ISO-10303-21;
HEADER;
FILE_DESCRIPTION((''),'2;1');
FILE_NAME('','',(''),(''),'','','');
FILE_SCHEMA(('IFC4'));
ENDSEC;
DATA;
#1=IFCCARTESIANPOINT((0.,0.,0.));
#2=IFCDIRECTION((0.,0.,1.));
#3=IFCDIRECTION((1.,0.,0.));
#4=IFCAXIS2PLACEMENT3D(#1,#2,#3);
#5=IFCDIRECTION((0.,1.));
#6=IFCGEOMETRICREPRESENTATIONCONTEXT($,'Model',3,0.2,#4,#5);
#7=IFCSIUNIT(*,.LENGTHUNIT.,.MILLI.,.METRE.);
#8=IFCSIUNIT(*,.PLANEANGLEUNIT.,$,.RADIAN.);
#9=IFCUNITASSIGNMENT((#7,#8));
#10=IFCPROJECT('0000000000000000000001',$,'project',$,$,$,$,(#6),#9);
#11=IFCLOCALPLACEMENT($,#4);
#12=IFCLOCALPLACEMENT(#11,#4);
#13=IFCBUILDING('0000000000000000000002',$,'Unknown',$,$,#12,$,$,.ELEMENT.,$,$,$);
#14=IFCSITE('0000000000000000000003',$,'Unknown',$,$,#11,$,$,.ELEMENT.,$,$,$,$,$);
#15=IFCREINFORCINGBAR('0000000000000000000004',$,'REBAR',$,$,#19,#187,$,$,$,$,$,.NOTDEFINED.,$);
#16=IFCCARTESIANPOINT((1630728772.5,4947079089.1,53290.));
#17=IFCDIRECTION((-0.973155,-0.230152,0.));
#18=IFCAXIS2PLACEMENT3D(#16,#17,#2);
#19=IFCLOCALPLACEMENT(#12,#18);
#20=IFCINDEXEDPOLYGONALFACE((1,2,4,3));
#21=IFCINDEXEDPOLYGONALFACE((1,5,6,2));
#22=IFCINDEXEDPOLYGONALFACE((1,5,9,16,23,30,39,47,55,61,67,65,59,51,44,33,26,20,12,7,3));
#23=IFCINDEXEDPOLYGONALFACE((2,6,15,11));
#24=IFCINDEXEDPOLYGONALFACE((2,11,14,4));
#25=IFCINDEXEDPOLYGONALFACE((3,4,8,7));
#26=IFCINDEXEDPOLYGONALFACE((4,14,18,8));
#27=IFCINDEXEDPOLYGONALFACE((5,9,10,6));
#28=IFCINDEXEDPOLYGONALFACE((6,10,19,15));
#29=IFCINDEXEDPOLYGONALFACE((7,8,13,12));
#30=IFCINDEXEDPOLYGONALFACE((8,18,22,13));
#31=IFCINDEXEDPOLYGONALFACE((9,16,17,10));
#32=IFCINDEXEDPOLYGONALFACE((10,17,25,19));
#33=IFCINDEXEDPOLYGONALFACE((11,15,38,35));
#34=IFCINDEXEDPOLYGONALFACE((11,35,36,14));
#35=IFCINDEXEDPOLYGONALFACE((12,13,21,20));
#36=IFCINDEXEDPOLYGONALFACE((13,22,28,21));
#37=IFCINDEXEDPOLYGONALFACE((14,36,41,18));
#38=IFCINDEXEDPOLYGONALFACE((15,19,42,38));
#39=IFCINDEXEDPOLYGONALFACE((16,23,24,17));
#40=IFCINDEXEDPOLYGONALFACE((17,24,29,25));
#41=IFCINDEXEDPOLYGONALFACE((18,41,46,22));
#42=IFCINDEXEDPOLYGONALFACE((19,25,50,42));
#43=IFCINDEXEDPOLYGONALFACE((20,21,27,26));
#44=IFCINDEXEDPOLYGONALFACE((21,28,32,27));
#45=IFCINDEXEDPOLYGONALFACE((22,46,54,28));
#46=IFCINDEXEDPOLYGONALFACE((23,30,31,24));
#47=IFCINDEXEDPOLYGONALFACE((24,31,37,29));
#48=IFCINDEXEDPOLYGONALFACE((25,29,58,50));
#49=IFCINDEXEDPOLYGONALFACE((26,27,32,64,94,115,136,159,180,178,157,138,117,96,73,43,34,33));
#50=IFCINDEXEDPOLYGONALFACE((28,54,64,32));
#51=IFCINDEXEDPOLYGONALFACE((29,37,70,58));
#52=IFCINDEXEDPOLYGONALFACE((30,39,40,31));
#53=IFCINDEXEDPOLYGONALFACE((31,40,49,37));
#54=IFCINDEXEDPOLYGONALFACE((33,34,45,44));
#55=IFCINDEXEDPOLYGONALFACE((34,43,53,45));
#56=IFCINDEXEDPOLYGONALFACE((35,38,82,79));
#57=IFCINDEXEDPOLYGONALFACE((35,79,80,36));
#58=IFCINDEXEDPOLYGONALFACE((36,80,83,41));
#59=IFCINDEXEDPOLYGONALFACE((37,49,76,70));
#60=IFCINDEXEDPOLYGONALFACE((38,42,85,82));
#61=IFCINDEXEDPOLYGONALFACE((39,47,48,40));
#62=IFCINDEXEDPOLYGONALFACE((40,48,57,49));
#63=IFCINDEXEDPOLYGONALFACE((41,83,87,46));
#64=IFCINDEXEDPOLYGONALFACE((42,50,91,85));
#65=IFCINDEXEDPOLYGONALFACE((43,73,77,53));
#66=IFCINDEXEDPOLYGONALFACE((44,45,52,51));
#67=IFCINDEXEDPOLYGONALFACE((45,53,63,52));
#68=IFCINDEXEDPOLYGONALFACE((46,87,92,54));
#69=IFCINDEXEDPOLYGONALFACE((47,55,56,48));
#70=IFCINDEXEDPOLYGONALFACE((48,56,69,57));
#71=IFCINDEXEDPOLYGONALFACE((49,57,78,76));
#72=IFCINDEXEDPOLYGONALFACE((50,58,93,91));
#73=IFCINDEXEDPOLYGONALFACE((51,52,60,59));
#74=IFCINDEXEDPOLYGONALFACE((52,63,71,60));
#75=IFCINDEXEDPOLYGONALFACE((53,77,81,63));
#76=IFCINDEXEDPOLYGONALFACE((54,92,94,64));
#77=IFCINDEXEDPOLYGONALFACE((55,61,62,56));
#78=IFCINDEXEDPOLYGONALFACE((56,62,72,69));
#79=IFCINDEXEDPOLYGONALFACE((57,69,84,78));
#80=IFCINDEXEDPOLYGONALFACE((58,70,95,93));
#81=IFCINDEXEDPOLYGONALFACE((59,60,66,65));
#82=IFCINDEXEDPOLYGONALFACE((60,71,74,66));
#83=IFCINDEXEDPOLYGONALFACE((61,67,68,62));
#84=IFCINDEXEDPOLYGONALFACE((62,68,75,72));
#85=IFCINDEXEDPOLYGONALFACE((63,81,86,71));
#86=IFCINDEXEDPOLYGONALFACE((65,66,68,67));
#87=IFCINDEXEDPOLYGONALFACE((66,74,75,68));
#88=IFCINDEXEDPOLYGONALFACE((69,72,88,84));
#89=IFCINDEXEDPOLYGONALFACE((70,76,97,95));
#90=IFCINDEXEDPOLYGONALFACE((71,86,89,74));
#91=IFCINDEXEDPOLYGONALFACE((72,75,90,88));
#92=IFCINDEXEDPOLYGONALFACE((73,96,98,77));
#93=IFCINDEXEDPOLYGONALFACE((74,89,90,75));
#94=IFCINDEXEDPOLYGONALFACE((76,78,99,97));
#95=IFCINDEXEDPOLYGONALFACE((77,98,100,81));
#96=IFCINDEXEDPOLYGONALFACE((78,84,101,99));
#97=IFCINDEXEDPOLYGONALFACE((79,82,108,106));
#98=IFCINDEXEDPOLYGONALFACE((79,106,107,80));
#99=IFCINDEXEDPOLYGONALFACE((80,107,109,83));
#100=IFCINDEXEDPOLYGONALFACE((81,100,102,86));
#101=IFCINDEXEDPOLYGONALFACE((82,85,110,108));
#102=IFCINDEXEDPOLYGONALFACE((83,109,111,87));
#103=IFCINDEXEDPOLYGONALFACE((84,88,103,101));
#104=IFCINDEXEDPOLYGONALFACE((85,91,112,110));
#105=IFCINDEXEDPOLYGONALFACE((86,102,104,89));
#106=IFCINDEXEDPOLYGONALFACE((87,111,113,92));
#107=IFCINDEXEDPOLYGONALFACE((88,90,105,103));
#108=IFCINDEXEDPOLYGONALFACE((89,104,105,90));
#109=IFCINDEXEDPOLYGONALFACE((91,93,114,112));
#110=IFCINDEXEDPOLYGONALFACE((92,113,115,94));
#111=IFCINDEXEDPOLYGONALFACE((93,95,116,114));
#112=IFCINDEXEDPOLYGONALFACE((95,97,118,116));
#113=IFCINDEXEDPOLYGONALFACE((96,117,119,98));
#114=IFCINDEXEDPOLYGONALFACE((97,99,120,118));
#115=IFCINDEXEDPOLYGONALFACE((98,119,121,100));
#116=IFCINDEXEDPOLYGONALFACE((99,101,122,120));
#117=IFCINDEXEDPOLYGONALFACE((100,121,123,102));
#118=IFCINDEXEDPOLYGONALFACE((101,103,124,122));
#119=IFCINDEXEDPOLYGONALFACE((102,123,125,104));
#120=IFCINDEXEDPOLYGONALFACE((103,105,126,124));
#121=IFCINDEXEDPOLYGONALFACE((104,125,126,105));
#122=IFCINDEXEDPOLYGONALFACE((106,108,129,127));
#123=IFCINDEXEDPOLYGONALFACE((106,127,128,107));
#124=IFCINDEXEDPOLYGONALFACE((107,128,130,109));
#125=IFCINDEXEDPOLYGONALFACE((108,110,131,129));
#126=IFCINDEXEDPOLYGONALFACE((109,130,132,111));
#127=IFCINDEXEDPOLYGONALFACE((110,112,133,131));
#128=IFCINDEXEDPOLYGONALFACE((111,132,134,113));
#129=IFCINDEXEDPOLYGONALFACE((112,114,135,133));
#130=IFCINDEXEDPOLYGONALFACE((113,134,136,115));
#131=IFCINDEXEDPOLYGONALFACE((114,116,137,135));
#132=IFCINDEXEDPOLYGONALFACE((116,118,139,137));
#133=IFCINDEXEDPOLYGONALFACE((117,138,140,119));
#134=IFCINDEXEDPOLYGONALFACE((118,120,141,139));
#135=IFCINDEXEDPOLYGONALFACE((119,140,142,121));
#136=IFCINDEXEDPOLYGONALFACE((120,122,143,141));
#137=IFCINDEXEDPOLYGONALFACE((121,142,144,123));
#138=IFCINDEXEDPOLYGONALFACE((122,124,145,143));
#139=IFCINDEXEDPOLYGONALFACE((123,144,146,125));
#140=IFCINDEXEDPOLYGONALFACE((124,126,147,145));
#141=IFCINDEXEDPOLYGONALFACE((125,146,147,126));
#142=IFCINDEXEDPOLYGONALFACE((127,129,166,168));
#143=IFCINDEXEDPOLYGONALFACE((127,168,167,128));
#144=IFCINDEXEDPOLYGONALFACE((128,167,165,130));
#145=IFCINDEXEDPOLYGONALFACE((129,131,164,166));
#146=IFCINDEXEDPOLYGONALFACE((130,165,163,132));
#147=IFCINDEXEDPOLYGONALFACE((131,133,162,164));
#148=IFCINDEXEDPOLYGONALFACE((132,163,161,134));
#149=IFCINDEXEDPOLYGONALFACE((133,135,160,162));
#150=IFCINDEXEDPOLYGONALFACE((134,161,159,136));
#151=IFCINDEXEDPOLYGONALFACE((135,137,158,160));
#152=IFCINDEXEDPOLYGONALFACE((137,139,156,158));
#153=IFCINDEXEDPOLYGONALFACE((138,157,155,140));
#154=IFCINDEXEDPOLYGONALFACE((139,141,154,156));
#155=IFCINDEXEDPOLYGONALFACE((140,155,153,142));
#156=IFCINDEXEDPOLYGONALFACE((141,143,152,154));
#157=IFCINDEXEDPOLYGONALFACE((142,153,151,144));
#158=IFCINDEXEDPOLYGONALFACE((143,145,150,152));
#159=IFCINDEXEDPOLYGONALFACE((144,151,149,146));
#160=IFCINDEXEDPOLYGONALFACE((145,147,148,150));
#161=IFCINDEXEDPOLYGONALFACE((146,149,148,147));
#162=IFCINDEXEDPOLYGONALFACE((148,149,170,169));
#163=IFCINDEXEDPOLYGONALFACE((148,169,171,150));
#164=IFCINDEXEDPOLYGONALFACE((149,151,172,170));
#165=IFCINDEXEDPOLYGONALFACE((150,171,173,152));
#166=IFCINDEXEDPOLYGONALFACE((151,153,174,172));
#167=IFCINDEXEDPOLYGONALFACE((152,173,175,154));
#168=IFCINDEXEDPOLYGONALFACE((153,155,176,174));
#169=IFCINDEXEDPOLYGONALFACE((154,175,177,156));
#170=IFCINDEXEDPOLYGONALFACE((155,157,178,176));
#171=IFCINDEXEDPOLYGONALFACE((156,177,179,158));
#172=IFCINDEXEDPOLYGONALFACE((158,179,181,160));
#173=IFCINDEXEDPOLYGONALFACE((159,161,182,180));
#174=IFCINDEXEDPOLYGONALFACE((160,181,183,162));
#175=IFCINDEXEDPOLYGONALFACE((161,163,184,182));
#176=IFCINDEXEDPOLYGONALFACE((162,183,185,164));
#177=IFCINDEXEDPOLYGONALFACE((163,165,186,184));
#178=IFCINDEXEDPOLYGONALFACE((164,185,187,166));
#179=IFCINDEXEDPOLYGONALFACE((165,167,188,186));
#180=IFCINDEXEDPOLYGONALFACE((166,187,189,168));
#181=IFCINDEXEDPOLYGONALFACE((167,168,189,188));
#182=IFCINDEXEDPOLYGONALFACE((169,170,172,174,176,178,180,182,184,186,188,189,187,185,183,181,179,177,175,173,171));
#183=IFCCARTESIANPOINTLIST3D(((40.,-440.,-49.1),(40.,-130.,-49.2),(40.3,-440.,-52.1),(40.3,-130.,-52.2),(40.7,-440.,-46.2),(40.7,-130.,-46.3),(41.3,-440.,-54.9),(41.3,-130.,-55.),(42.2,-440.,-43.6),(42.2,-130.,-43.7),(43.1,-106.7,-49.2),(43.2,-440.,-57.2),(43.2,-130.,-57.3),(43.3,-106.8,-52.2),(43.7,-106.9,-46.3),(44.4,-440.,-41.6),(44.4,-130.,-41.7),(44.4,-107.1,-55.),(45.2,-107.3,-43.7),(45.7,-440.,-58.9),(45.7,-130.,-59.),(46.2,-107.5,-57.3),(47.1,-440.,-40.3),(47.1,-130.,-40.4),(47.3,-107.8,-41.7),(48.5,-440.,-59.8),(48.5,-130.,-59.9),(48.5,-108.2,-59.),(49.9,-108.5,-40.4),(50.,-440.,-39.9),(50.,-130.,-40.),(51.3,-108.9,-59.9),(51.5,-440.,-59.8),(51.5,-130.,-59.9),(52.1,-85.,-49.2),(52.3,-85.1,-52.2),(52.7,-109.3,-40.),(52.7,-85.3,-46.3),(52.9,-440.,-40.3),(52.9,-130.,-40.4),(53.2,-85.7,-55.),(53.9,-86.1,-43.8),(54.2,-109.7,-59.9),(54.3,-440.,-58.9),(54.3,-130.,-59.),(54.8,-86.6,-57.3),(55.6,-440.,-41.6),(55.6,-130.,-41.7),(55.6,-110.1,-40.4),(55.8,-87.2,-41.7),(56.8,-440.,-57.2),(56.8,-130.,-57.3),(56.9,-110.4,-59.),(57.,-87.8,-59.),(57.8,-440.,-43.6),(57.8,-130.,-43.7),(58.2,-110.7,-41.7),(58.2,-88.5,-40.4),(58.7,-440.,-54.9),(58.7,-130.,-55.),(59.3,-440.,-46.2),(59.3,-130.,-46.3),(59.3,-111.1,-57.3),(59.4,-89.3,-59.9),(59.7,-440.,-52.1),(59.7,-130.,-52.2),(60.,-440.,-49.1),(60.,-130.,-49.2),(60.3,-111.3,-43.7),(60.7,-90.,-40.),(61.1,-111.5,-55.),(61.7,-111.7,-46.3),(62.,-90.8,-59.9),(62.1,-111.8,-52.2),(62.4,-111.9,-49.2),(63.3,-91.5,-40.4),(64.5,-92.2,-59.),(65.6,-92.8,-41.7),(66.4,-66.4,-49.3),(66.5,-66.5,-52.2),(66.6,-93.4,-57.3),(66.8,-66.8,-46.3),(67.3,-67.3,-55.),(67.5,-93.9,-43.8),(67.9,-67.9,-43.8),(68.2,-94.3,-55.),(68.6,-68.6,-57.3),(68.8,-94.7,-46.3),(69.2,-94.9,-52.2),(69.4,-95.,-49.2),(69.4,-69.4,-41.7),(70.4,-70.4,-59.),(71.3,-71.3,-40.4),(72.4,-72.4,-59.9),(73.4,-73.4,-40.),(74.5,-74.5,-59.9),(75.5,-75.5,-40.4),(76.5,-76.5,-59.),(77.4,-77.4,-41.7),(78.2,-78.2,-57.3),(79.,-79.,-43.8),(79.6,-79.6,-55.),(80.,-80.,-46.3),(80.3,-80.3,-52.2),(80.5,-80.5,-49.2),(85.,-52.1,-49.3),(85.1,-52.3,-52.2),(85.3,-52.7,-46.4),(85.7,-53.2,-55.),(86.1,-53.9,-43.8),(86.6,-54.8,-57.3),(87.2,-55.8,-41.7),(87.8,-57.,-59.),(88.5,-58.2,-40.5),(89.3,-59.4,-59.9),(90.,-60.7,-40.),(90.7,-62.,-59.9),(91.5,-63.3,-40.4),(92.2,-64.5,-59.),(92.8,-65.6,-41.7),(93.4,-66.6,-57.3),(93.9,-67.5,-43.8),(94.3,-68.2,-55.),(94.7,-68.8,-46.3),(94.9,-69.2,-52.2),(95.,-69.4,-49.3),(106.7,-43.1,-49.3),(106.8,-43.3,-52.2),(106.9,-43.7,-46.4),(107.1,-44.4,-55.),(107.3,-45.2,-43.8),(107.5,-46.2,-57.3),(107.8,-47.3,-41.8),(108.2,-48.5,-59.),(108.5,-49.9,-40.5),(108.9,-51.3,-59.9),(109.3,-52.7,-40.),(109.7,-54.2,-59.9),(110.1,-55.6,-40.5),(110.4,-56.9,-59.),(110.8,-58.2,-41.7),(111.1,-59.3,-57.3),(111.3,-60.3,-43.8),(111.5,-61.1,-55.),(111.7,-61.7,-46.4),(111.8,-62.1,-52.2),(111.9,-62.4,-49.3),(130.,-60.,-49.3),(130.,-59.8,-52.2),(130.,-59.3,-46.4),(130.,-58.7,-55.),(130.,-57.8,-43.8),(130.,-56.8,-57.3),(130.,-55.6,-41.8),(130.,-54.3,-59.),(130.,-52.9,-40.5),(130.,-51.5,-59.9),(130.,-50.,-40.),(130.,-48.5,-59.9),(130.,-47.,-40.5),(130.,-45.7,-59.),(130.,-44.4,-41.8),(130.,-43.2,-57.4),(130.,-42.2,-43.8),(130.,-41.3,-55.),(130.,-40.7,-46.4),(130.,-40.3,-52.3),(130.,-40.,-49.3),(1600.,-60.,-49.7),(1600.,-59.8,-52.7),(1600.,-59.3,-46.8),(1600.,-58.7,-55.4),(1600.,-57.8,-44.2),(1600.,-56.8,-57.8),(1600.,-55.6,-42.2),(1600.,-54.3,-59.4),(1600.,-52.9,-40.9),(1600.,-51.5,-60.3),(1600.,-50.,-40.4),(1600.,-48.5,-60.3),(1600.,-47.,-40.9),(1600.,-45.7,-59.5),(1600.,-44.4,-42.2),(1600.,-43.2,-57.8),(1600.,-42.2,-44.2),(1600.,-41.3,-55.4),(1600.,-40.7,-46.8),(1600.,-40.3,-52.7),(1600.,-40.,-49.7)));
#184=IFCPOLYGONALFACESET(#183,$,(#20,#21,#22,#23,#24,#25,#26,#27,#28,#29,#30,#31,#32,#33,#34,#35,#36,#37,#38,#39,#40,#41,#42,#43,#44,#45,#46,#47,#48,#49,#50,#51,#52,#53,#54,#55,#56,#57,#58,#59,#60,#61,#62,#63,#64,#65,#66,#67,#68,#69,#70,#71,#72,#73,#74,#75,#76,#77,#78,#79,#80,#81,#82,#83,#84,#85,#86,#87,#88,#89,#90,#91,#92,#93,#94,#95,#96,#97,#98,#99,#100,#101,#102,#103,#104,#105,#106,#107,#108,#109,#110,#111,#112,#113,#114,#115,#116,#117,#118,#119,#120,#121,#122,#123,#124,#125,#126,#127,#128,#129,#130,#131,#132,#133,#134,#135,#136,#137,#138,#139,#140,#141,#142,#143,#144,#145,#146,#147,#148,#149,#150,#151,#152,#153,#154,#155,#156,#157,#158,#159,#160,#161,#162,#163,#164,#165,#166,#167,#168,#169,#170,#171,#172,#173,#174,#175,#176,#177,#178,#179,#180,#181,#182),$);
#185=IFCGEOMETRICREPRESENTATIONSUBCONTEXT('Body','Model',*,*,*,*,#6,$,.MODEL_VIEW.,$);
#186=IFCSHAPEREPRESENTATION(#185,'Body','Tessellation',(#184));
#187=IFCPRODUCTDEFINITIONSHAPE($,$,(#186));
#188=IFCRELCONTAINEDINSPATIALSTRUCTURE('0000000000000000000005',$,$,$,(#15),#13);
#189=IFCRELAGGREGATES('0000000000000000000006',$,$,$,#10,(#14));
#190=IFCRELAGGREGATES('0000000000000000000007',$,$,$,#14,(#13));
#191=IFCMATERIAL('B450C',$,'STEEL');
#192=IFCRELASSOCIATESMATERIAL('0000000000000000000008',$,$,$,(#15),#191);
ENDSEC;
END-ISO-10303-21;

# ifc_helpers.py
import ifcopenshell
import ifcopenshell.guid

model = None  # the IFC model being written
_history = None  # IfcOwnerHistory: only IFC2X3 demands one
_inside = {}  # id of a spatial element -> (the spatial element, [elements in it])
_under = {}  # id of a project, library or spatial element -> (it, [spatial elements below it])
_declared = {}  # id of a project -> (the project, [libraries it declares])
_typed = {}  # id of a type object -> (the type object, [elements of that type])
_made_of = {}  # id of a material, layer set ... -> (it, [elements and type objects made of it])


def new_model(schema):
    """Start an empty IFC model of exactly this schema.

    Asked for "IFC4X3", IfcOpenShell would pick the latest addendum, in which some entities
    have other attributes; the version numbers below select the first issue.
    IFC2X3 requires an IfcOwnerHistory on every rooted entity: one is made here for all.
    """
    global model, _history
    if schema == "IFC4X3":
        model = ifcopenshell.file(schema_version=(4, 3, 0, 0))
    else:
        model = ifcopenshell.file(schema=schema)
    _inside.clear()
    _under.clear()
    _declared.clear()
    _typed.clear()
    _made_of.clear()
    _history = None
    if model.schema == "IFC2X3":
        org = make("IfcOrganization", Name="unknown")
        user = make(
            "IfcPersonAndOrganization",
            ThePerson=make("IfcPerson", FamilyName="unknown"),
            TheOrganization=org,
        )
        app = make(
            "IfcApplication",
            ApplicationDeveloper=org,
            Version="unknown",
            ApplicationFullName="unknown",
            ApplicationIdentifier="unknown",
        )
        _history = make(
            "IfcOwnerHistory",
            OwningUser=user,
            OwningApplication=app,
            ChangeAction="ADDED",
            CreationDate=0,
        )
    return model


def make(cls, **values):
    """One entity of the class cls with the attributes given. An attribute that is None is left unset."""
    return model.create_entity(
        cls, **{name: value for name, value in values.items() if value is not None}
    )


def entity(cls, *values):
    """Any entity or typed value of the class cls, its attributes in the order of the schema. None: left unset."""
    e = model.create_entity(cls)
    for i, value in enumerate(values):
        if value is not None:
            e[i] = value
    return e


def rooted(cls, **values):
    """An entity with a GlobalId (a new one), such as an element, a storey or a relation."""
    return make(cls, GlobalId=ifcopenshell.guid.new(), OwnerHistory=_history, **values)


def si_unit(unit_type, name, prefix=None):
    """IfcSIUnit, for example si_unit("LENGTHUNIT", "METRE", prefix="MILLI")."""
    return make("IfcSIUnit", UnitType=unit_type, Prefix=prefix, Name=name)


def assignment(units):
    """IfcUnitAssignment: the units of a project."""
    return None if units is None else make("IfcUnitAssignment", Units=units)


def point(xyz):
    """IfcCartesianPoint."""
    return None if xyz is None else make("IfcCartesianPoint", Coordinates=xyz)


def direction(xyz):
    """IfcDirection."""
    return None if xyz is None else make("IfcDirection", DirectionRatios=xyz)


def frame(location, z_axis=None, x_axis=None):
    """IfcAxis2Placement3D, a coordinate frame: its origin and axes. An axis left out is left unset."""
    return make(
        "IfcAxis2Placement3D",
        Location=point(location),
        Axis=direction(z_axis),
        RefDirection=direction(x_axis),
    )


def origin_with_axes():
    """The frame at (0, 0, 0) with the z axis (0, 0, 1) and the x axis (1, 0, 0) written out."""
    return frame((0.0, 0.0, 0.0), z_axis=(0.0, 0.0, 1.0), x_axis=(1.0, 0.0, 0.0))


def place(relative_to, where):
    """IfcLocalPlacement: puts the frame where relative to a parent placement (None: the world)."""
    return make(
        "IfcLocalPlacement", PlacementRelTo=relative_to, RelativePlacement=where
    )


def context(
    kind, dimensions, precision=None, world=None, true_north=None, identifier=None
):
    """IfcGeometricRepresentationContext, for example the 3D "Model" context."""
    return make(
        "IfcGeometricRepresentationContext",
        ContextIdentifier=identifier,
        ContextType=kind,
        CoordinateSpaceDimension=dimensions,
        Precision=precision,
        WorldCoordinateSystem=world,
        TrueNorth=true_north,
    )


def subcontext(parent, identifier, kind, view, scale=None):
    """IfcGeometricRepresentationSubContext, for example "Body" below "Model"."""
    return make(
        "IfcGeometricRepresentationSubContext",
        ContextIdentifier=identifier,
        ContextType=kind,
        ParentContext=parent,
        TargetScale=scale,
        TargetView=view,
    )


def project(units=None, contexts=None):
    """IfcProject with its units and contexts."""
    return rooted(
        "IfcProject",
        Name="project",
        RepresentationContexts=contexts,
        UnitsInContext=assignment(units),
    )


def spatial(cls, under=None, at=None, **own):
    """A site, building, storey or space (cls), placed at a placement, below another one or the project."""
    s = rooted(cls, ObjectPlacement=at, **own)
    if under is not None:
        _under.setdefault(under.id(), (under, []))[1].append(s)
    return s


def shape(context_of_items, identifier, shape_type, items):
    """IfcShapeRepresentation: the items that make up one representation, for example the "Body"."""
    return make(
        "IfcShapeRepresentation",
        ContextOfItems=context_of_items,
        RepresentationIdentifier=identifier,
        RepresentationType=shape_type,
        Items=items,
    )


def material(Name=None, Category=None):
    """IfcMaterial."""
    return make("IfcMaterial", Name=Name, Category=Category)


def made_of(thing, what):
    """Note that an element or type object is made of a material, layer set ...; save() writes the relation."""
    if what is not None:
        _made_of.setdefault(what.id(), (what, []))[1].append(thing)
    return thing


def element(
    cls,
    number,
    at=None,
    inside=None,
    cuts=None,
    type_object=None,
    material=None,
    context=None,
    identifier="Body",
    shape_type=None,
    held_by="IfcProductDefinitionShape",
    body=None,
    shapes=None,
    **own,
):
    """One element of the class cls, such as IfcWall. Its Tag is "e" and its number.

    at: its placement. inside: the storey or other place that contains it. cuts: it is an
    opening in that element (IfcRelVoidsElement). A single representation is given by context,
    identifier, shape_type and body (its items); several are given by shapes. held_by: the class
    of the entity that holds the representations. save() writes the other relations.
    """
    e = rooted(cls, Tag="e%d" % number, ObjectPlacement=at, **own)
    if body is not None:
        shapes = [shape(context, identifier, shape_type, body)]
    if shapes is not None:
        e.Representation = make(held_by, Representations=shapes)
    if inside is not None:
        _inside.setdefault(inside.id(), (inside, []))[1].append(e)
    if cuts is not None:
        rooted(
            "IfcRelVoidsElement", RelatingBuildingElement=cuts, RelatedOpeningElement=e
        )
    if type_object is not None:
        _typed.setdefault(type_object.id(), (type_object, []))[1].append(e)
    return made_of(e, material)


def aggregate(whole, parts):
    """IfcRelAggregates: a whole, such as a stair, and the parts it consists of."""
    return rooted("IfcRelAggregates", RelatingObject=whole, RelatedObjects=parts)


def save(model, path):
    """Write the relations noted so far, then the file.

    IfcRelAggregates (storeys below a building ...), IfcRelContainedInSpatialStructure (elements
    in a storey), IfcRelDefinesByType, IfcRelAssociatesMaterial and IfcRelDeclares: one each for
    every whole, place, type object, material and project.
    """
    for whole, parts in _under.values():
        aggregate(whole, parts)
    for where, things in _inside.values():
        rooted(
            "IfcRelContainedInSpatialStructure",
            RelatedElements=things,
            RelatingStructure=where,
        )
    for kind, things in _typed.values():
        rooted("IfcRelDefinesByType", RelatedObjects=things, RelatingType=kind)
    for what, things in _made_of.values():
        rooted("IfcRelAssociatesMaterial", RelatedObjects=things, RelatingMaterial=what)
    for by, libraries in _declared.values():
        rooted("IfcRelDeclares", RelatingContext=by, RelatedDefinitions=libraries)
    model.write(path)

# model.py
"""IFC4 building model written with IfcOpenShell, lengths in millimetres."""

from ifc_helpers import new_model, entity, si_unit, direction, frame, origin_with_axes, place, context, subcontext, project, spatial, material, element, save


model = new_model("IFC4")

# Units and contexts
model_context = context("Model", 3, precision=0.2, world=origin_with_axes(), true_north=direction((0.0, 1.0)))
body_context = subcontext(model_context, "Body", "Model", "MODEL_VIEW")
ifc_project = project(units=[si_unit("LENGTHUNIT", "METRE", prefix="MILLI"), si_unit("PLANEANGLEUNIT", "RADIAN")], contexts=[model_context])

# Site, building
site_placement = place(None, origin_with_axes())
site = spatial("IfcSite", under=ifc_project, at=site_placement, Name="Unknown", CompositionType="ELEMENT")
building_placement = place(site_placement, origin_with_axes())
building = spatial("IfcBuilding", under=site, at=building_placement, Name="Unknown", CompositionType="ELEMENT")

# Reinforcing bar
ifc_material = material(Name="B450C", Category="STEEL")
reinforcing_bar_1_placement = place(building_placement, frame((1630728772.5, 4947079089.1, 53290.0), z_axis=(-0.973155, -0.230152, 0.0), x_axis=(0.0, 0.0, 1.0)))
element("IfcReinforcingBar", 1, at=reinforcing_bar_1_placement, inside=building, material=ifc_material, Name="REBAR", PredefinedType="NOTDEFINED", context=body_context, shape_type="AdvancedSweptSolid", body=[
    entity("IfcSweptDiskSolid", entity("IfcIndexedPolyCurve", entity("IfcCartesianPointList3D", [[50.0, -440.0, -49.9], [50.0, -130.0, -50.0], [73.4, -73.4, -50.0], [130.0, -50.0, -50.0], [1600.0, -50.0, -50.4]]), [entity("IfcLineIndex", [1, 2]), entity("IfcArcIndex", [2, 3, 4]), entity("IfcLineIndex", [4, 5])]), 10.0),
])

save(model, "model.ifc")
